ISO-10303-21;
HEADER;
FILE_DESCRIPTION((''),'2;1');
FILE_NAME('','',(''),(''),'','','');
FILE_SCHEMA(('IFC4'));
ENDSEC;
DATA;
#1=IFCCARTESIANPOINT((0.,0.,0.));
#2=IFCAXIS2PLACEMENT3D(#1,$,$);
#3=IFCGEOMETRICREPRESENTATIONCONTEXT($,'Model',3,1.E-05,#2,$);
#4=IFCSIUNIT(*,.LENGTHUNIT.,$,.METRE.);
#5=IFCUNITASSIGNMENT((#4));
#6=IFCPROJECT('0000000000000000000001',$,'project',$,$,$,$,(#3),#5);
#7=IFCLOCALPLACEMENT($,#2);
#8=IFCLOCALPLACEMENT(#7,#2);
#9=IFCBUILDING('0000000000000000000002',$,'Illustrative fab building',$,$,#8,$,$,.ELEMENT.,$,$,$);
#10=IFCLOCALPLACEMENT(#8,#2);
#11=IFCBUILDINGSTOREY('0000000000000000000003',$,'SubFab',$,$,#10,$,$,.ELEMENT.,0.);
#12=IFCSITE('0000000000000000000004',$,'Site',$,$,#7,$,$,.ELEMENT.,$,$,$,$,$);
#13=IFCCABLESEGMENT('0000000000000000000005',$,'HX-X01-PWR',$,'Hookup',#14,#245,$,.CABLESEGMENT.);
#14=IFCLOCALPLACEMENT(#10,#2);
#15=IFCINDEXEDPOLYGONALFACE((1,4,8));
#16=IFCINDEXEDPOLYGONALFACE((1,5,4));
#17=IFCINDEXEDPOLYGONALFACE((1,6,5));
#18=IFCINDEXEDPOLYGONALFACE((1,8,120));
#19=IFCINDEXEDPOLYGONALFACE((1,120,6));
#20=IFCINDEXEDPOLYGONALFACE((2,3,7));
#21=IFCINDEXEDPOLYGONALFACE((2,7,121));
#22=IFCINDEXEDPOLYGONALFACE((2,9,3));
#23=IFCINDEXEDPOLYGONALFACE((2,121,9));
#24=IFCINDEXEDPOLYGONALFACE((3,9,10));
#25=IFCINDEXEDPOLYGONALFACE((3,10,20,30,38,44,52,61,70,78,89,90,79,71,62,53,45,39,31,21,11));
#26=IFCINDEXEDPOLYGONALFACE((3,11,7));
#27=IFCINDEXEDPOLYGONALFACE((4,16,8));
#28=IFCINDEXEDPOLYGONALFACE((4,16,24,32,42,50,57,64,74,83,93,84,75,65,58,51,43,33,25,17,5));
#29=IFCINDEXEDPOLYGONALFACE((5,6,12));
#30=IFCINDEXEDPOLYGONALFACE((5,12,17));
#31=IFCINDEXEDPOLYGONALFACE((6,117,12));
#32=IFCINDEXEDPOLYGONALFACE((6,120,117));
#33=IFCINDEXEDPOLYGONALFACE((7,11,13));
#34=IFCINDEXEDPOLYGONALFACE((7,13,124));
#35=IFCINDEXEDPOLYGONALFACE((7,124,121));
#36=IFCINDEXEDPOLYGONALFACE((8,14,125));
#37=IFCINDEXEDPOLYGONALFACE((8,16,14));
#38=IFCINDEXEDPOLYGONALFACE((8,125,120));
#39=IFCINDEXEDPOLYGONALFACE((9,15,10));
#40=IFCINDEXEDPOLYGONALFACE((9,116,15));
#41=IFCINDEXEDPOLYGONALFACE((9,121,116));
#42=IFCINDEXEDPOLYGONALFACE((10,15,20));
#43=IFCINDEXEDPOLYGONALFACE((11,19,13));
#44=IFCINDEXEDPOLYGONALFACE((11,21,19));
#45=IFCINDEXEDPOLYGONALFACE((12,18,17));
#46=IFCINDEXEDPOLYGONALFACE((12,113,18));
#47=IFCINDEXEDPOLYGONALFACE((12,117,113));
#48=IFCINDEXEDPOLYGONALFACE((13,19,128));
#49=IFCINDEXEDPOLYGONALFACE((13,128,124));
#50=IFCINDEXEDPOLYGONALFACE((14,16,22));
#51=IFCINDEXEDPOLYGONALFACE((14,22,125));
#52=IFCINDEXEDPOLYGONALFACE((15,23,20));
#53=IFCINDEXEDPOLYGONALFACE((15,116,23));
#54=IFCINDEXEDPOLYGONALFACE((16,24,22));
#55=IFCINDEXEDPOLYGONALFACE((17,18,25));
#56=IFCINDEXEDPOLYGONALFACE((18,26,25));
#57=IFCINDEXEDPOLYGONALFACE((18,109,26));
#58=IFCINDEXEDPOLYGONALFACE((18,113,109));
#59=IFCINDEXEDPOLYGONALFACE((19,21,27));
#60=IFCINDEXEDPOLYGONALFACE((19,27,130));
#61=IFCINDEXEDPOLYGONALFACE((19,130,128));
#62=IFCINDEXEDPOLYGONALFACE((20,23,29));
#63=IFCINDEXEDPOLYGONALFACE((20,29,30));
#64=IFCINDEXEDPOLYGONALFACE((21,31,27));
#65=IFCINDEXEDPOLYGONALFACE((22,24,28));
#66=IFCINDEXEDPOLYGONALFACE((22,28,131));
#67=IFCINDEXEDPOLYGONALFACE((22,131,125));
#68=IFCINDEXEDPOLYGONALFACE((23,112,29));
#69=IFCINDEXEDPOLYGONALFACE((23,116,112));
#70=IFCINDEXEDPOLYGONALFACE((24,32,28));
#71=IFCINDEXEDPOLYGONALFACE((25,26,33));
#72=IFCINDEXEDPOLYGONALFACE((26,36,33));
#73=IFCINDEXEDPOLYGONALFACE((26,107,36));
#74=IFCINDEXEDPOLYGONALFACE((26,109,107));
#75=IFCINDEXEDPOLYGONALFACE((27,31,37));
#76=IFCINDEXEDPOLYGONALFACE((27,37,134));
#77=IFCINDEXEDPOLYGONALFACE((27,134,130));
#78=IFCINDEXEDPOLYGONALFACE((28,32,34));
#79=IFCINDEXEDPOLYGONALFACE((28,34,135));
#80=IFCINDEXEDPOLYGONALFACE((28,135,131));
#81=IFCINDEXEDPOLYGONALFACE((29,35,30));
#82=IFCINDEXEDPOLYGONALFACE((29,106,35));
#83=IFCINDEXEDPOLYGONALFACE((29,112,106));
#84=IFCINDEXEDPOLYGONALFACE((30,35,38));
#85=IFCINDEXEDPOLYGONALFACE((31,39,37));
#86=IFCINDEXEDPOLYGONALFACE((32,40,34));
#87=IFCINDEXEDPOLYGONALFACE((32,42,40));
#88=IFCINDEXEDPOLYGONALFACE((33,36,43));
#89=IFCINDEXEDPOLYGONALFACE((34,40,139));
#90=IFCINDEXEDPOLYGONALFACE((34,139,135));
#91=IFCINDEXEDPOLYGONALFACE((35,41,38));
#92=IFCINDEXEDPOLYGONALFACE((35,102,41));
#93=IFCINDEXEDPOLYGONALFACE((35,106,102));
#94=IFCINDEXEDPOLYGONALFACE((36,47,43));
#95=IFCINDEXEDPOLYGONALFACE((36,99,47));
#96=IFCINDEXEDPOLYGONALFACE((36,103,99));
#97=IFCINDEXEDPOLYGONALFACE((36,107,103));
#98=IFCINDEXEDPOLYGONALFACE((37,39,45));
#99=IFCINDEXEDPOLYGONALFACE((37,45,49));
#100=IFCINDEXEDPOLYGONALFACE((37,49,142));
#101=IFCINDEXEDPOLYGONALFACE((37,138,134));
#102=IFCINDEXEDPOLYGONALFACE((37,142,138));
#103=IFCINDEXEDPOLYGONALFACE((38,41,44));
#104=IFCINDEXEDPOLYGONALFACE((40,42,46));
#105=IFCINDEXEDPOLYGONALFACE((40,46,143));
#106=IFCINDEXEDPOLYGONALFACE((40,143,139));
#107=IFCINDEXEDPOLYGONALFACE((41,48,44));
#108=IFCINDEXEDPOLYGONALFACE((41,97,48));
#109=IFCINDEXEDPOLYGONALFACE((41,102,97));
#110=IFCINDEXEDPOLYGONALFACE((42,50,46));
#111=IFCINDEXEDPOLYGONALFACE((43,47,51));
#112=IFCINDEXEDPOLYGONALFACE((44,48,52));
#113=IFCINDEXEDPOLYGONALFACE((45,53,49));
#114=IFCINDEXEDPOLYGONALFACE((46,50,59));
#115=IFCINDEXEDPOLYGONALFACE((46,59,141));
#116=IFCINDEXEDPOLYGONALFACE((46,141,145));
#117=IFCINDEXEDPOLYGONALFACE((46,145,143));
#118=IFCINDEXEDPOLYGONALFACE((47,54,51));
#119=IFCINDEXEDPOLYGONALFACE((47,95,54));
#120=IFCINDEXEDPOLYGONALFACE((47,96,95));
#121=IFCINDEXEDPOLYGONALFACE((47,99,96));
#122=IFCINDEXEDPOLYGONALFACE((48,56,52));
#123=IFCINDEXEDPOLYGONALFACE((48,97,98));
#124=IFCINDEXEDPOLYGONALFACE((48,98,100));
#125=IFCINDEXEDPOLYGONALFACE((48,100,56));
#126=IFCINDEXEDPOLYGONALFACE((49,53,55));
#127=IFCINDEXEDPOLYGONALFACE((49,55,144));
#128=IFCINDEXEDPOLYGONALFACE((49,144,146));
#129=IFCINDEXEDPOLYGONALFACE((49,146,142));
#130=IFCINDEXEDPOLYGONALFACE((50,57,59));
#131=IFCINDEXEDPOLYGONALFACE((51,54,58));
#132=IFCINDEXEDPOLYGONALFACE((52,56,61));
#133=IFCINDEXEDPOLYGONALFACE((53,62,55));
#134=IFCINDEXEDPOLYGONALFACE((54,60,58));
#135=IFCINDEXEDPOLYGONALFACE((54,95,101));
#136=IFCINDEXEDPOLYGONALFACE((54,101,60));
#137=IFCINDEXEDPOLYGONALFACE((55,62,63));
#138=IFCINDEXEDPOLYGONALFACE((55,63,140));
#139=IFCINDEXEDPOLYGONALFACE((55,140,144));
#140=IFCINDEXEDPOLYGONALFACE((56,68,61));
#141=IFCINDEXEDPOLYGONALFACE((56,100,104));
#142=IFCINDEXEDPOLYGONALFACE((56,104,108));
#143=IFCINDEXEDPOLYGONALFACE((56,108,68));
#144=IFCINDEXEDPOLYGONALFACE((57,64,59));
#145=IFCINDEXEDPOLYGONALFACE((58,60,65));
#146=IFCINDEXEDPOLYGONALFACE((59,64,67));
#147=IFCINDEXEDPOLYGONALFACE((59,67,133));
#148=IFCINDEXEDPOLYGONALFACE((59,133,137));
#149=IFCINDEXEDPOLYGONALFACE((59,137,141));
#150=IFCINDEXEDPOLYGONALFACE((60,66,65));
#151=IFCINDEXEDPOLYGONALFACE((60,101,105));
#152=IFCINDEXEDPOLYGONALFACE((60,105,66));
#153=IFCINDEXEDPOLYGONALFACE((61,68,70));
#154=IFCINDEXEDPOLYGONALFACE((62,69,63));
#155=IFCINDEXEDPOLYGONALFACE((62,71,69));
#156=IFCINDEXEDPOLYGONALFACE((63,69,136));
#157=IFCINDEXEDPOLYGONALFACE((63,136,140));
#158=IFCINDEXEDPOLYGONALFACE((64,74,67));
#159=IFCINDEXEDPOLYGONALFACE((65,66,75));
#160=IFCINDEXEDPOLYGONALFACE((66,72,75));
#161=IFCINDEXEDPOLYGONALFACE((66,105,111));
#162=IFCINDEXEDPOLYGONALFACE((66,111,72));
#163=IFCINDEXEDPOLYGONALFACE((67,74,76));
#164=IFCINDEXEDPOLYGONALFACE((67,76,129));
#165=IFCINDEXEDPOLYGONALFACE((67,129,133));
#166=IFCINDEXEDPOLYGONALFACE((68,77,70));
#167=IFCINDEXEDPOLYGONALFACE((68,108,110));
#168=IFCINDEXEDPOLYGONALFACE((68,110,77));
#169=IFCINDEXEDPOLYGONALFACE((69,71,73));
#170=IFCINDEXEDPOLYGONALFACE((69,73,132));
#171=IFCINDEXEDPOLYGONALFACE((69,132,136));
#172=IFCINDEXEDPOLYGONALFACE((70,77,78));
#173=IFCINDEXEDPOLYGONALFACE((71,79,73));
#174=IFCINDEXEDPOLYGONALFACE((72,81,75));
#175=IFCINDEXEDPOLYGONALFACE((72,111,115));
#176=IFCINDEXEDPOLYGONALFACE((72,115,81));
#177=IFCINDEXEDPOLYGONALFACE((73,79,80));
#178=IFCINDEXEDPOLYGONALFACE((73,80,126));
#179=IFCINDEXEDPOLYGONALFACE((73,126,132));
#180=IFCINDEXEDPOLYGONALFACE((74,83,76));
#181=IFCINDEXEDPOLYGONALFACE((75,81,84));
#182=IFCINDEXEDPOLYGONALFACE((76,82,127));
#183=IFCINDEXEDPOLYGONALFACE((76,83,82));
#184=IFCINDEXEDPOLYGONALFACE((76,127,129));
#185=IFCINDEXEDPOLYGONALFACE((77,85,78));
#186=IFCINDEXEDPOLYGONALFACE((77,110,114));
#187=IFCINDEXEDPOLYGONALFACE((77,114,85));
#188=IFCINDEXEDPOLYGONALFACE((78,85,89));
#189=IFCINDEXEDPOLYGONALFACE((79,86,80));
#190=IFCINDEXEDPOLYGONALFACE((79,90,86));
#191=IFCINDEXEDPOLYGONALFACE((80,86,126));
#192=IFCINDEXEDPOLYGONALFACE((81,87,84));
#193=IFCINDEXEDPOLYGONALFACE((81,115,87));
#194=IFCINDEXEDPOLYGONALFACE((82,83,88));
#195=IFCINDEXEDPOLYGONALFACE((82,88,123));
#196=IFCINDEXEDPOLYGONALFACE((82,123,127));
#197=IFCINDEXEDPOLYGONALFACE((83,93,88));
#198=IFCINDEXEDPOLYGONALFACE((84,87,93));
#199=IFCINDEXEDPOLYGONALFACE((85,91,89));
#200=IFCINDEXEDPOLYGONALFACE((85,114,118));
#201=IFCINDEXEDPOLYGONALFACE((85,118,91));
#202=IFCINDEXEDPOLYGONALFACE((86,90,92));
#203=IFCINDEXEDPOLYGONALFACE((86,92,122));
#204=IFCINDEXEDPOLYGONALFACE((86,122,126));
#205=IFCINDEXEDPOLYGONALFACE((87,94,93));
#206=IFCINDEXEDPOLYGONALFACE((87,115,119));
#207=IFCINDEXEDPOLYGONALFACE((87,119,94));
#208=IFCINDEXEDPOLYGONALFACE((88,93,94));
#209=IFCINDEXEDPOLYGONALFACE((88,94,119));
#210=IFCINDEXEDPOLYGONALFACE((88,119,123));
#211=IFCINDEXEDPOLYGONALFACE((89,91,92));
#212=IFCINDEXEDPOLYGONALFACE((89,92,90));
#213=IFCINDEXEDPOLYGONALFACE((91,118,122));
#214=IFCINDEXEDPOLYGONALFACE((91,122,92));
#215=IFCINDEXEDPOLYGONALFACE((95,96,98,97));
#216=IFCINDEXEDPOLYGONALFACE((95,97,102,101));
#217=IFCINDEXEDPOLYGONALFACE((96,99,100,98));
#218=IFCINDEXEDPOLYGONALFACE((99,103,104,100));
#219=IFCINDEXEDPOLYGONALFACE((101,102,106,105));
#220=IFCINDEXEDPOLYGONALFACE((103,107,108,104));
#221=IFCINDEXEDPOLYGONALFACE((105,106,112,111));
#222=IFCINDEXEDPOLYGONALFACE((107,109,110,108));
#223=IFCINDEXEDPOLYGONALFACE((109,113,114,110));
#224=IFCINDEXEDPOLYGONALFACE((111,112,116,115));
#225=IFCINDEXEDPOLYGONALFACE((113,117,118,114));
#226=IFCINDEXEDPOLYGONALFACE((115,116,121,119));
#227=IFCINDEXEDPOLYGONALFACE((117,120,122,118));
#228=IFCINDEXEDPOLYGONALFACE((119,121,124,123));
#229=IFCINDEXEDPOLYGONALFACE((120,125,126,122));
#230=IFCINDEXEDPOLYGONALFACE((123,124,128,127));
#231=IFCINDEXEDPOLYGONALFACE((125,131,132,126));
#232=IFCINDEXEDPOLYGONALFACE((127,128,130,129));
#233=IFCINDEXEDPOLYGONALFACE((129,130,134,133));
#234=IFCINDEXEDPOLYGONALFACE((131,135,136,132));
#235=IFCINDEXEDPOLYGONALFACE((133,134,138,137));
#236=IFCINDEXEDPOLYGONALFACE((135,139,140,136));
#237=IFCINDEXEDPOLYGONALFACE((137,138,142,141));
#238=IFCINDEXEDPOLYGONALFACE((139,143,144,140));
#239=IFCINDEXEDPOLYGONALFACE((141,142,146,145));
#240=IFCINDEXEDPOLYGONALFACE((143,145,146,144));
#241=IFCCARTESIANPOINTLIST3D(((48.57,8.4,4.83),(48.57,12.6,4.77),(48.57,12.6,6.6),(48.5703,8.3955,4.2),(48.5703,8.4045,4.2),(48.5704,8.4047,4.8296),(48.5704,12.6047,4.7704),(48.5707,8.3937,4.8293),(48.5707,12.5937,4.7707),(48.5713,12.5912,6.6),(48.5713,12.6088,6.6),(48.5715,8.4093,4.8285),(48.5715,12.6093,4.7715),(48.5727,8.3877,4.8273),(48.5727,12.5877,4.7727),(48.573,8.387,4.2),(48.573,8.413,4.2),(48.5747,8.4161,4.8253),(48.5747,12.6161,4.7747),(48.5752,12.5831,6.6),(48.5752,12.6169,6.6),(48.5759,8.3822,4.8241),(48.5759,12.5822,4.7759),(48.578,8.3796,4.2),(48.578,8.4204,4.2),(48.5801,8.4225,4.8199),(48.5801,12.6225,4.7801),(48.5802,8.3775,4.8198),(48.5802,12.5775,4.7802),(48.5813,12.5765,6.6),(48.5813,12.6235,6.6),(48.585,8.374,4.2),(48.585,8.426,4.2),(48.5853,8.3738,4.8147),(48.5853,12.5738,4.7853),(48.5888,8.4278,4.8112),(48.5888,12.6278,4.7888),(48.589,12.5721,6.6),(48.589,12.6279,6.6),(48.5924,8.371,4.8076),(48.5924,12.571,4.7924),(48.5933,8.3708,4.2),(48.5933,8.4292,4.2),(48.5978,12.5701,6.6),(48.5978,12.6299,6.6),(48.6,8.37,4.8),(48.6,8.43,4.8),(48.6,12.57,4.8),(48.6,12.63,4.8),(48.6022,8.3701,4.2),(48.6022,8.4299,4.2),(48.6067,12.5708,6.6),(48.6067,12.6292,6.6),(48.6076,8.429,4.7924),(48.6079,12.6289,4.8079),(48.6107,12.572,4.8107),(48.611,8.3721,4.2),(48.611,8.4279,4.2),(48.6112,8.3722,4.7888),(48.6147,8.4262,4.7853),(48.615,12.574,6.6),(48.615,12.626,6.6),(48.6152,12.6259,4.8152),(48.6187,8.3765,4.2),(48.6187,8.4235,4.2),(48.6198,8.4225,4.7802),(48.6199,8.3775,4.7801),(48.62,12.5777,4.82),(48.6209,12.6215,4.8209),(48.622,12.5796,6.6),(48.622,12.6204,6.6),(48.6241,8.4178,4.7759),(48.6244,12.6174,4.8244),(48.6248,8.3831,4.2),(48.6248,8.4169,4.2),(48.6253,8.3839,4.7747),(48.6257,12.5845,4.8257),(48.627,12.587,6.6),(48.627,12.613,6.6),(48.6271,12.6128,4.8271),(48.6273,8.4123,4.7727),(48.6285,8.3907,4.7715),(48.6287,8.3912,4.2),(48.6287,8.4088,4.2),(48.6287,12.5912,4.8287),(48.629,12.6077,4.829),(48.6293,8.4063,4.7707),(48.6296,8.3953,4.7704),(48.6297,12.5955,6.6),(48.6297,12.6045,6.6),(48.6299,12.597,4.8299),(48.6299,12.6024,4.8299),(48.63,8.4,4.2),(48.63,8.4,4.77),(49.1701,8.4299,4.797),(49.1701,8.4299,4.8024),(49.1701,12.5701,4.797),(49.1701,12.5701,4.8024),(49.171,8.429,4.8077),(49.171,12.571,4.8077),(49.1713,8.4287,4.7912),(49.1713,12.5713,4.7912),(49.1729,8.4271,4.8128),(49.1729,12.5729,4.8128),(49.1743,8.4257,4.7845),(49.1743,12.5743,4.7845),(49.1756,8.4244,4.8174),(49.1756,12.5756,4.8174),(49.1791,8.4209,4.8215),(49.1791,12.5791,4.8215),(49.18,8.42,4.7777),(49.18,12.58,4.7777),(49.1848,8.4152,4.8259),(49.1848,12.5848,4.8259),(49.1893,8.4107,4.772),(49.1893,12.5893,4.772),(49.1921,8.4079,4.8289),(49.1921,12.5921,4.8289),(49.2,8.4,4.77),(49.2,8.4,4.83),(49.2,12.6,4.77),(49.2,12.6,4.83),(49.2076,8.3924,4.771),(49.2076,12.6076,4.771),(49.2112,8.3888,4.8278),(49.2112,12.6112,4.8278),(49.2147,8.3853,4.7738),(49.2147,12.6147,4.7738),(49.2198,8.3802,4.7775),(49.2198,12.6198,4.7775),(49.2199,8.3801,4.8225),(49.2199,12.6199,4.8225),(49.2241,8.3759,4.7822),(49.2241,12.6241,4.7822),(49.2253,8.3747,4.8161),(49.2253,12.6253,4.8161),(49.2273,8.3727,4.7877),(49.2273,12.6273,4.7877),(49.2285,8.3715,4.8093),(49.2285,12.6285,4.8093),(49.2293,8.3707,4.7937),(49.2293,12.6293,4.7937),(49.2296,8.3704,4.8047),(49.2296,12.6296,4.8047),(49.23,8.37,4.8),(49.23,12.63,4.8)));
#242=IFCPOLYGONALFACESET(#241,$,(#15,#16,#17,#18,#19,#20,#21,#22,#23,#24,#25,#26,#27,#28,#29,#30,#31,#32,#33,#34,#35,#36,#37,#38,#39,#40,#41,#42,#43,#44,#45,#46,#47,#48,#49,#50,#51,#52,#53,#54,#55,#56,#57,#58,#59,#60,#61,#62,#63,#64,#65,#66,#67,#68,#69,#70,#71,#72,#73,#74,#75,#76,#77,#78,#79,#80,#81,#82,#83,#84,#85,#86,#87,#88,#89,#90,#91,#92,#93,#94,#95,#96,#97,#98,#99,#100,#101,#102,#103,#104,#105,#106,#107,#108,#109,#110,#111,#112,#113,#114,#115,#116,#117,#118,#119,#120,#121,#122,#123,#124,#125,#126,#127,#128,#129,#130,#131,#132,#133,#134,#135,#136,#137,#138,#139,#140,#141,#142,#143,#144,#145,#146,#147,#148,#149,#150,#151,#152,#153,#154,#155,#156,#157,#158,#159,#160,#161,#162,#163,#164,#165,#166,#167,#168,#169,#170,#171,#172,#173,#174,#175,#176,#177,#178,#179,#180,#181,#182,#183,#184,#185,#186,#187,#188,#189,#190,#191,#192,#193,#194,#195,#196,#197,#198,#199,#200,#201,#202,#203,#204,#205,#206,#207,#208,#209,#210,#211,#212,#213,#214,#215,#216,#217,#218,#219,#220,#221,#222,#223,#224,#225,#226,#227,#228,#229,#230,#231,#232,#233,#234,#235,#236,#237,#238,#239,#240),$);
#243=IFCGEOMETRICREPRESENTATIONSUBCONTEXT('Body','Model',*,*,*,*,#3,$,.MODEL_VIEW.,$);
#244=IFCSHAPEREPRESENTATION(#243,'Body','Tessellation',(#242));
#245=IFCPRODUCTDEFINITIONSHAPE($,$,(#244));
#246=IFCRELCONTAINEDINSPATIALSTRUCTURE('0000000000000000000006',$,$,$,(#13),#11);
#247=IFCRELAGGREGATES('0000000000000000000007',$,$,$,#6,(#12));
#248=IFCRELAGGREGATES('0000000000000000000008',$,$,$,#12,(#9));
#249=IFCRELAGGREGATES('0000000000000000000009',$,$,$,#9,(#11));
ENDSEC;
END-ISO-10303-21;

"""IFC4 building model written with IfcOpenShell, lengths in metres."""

from ifc_helpers import new_model, entity, si_unit, origin, place, context, subcontext, project, spatial, element, save


model = new_model("IFC4")

# Units and contexts
model_context = context("Model", 3, precision=1e-05, world=origin())
body_context = subcontext(model_context, "Body", "Model", "MODEL_VIEW")
ifc_project = project(units=[si_unit("LENGTHUNIT", "METRE")], contexts=[model_context])

# Site, building, storey
site_placement = place(None, origin())
site = spatial("IfcSite", under=ifc_project, at=site_placement, Name="Site", CompositionType="ELEMENT")
building_placement = place(site_placement, origin())
building = spatial("IfcBuilding", under=site, at=building_placement, Name="Illustrative fab building", CompositionType="ELEMENT")
storey_placement = place(building_placement, origin())
storey = spatial("IfcBuildingStorey", under=building, at=storey_placement, Name="SubFab", CompositionType="ELEMENT", Elevation=0.0)

# Cable segment
cable_segment_1_placement = place(storey_placement, origin())
element("IfcCableSegment", 1, at=cable_segment_1_placement, inside=storey, Name="HX-X01-PWR", ObjectType="Hookup", PredefinedType="CABLESEGMENT", context=body_context, shape_type="AdvancedSweptSolid", body=[
    entity("IfcSweptDiskSolid", entity("IfcPolyline", [entity("IfcCartesianPoint", [48.6, 8.4, 4.2]), entity("IfcCartesianPoint", [48.6, 8.4, 4.8]), entity("IfcCartesianPoint", [49.2, 8.4, 4.8]), entity("IfcCartesianPoint", [49.2, 12.6, 4.8]), entity("IfcCartesianPoint", [48.6, 12.6, 4.8]), entity("IfcCartesianPoint", [48.6, 12.6, 6.6])]), 0.03),
])

save(model, "model.ifc")
